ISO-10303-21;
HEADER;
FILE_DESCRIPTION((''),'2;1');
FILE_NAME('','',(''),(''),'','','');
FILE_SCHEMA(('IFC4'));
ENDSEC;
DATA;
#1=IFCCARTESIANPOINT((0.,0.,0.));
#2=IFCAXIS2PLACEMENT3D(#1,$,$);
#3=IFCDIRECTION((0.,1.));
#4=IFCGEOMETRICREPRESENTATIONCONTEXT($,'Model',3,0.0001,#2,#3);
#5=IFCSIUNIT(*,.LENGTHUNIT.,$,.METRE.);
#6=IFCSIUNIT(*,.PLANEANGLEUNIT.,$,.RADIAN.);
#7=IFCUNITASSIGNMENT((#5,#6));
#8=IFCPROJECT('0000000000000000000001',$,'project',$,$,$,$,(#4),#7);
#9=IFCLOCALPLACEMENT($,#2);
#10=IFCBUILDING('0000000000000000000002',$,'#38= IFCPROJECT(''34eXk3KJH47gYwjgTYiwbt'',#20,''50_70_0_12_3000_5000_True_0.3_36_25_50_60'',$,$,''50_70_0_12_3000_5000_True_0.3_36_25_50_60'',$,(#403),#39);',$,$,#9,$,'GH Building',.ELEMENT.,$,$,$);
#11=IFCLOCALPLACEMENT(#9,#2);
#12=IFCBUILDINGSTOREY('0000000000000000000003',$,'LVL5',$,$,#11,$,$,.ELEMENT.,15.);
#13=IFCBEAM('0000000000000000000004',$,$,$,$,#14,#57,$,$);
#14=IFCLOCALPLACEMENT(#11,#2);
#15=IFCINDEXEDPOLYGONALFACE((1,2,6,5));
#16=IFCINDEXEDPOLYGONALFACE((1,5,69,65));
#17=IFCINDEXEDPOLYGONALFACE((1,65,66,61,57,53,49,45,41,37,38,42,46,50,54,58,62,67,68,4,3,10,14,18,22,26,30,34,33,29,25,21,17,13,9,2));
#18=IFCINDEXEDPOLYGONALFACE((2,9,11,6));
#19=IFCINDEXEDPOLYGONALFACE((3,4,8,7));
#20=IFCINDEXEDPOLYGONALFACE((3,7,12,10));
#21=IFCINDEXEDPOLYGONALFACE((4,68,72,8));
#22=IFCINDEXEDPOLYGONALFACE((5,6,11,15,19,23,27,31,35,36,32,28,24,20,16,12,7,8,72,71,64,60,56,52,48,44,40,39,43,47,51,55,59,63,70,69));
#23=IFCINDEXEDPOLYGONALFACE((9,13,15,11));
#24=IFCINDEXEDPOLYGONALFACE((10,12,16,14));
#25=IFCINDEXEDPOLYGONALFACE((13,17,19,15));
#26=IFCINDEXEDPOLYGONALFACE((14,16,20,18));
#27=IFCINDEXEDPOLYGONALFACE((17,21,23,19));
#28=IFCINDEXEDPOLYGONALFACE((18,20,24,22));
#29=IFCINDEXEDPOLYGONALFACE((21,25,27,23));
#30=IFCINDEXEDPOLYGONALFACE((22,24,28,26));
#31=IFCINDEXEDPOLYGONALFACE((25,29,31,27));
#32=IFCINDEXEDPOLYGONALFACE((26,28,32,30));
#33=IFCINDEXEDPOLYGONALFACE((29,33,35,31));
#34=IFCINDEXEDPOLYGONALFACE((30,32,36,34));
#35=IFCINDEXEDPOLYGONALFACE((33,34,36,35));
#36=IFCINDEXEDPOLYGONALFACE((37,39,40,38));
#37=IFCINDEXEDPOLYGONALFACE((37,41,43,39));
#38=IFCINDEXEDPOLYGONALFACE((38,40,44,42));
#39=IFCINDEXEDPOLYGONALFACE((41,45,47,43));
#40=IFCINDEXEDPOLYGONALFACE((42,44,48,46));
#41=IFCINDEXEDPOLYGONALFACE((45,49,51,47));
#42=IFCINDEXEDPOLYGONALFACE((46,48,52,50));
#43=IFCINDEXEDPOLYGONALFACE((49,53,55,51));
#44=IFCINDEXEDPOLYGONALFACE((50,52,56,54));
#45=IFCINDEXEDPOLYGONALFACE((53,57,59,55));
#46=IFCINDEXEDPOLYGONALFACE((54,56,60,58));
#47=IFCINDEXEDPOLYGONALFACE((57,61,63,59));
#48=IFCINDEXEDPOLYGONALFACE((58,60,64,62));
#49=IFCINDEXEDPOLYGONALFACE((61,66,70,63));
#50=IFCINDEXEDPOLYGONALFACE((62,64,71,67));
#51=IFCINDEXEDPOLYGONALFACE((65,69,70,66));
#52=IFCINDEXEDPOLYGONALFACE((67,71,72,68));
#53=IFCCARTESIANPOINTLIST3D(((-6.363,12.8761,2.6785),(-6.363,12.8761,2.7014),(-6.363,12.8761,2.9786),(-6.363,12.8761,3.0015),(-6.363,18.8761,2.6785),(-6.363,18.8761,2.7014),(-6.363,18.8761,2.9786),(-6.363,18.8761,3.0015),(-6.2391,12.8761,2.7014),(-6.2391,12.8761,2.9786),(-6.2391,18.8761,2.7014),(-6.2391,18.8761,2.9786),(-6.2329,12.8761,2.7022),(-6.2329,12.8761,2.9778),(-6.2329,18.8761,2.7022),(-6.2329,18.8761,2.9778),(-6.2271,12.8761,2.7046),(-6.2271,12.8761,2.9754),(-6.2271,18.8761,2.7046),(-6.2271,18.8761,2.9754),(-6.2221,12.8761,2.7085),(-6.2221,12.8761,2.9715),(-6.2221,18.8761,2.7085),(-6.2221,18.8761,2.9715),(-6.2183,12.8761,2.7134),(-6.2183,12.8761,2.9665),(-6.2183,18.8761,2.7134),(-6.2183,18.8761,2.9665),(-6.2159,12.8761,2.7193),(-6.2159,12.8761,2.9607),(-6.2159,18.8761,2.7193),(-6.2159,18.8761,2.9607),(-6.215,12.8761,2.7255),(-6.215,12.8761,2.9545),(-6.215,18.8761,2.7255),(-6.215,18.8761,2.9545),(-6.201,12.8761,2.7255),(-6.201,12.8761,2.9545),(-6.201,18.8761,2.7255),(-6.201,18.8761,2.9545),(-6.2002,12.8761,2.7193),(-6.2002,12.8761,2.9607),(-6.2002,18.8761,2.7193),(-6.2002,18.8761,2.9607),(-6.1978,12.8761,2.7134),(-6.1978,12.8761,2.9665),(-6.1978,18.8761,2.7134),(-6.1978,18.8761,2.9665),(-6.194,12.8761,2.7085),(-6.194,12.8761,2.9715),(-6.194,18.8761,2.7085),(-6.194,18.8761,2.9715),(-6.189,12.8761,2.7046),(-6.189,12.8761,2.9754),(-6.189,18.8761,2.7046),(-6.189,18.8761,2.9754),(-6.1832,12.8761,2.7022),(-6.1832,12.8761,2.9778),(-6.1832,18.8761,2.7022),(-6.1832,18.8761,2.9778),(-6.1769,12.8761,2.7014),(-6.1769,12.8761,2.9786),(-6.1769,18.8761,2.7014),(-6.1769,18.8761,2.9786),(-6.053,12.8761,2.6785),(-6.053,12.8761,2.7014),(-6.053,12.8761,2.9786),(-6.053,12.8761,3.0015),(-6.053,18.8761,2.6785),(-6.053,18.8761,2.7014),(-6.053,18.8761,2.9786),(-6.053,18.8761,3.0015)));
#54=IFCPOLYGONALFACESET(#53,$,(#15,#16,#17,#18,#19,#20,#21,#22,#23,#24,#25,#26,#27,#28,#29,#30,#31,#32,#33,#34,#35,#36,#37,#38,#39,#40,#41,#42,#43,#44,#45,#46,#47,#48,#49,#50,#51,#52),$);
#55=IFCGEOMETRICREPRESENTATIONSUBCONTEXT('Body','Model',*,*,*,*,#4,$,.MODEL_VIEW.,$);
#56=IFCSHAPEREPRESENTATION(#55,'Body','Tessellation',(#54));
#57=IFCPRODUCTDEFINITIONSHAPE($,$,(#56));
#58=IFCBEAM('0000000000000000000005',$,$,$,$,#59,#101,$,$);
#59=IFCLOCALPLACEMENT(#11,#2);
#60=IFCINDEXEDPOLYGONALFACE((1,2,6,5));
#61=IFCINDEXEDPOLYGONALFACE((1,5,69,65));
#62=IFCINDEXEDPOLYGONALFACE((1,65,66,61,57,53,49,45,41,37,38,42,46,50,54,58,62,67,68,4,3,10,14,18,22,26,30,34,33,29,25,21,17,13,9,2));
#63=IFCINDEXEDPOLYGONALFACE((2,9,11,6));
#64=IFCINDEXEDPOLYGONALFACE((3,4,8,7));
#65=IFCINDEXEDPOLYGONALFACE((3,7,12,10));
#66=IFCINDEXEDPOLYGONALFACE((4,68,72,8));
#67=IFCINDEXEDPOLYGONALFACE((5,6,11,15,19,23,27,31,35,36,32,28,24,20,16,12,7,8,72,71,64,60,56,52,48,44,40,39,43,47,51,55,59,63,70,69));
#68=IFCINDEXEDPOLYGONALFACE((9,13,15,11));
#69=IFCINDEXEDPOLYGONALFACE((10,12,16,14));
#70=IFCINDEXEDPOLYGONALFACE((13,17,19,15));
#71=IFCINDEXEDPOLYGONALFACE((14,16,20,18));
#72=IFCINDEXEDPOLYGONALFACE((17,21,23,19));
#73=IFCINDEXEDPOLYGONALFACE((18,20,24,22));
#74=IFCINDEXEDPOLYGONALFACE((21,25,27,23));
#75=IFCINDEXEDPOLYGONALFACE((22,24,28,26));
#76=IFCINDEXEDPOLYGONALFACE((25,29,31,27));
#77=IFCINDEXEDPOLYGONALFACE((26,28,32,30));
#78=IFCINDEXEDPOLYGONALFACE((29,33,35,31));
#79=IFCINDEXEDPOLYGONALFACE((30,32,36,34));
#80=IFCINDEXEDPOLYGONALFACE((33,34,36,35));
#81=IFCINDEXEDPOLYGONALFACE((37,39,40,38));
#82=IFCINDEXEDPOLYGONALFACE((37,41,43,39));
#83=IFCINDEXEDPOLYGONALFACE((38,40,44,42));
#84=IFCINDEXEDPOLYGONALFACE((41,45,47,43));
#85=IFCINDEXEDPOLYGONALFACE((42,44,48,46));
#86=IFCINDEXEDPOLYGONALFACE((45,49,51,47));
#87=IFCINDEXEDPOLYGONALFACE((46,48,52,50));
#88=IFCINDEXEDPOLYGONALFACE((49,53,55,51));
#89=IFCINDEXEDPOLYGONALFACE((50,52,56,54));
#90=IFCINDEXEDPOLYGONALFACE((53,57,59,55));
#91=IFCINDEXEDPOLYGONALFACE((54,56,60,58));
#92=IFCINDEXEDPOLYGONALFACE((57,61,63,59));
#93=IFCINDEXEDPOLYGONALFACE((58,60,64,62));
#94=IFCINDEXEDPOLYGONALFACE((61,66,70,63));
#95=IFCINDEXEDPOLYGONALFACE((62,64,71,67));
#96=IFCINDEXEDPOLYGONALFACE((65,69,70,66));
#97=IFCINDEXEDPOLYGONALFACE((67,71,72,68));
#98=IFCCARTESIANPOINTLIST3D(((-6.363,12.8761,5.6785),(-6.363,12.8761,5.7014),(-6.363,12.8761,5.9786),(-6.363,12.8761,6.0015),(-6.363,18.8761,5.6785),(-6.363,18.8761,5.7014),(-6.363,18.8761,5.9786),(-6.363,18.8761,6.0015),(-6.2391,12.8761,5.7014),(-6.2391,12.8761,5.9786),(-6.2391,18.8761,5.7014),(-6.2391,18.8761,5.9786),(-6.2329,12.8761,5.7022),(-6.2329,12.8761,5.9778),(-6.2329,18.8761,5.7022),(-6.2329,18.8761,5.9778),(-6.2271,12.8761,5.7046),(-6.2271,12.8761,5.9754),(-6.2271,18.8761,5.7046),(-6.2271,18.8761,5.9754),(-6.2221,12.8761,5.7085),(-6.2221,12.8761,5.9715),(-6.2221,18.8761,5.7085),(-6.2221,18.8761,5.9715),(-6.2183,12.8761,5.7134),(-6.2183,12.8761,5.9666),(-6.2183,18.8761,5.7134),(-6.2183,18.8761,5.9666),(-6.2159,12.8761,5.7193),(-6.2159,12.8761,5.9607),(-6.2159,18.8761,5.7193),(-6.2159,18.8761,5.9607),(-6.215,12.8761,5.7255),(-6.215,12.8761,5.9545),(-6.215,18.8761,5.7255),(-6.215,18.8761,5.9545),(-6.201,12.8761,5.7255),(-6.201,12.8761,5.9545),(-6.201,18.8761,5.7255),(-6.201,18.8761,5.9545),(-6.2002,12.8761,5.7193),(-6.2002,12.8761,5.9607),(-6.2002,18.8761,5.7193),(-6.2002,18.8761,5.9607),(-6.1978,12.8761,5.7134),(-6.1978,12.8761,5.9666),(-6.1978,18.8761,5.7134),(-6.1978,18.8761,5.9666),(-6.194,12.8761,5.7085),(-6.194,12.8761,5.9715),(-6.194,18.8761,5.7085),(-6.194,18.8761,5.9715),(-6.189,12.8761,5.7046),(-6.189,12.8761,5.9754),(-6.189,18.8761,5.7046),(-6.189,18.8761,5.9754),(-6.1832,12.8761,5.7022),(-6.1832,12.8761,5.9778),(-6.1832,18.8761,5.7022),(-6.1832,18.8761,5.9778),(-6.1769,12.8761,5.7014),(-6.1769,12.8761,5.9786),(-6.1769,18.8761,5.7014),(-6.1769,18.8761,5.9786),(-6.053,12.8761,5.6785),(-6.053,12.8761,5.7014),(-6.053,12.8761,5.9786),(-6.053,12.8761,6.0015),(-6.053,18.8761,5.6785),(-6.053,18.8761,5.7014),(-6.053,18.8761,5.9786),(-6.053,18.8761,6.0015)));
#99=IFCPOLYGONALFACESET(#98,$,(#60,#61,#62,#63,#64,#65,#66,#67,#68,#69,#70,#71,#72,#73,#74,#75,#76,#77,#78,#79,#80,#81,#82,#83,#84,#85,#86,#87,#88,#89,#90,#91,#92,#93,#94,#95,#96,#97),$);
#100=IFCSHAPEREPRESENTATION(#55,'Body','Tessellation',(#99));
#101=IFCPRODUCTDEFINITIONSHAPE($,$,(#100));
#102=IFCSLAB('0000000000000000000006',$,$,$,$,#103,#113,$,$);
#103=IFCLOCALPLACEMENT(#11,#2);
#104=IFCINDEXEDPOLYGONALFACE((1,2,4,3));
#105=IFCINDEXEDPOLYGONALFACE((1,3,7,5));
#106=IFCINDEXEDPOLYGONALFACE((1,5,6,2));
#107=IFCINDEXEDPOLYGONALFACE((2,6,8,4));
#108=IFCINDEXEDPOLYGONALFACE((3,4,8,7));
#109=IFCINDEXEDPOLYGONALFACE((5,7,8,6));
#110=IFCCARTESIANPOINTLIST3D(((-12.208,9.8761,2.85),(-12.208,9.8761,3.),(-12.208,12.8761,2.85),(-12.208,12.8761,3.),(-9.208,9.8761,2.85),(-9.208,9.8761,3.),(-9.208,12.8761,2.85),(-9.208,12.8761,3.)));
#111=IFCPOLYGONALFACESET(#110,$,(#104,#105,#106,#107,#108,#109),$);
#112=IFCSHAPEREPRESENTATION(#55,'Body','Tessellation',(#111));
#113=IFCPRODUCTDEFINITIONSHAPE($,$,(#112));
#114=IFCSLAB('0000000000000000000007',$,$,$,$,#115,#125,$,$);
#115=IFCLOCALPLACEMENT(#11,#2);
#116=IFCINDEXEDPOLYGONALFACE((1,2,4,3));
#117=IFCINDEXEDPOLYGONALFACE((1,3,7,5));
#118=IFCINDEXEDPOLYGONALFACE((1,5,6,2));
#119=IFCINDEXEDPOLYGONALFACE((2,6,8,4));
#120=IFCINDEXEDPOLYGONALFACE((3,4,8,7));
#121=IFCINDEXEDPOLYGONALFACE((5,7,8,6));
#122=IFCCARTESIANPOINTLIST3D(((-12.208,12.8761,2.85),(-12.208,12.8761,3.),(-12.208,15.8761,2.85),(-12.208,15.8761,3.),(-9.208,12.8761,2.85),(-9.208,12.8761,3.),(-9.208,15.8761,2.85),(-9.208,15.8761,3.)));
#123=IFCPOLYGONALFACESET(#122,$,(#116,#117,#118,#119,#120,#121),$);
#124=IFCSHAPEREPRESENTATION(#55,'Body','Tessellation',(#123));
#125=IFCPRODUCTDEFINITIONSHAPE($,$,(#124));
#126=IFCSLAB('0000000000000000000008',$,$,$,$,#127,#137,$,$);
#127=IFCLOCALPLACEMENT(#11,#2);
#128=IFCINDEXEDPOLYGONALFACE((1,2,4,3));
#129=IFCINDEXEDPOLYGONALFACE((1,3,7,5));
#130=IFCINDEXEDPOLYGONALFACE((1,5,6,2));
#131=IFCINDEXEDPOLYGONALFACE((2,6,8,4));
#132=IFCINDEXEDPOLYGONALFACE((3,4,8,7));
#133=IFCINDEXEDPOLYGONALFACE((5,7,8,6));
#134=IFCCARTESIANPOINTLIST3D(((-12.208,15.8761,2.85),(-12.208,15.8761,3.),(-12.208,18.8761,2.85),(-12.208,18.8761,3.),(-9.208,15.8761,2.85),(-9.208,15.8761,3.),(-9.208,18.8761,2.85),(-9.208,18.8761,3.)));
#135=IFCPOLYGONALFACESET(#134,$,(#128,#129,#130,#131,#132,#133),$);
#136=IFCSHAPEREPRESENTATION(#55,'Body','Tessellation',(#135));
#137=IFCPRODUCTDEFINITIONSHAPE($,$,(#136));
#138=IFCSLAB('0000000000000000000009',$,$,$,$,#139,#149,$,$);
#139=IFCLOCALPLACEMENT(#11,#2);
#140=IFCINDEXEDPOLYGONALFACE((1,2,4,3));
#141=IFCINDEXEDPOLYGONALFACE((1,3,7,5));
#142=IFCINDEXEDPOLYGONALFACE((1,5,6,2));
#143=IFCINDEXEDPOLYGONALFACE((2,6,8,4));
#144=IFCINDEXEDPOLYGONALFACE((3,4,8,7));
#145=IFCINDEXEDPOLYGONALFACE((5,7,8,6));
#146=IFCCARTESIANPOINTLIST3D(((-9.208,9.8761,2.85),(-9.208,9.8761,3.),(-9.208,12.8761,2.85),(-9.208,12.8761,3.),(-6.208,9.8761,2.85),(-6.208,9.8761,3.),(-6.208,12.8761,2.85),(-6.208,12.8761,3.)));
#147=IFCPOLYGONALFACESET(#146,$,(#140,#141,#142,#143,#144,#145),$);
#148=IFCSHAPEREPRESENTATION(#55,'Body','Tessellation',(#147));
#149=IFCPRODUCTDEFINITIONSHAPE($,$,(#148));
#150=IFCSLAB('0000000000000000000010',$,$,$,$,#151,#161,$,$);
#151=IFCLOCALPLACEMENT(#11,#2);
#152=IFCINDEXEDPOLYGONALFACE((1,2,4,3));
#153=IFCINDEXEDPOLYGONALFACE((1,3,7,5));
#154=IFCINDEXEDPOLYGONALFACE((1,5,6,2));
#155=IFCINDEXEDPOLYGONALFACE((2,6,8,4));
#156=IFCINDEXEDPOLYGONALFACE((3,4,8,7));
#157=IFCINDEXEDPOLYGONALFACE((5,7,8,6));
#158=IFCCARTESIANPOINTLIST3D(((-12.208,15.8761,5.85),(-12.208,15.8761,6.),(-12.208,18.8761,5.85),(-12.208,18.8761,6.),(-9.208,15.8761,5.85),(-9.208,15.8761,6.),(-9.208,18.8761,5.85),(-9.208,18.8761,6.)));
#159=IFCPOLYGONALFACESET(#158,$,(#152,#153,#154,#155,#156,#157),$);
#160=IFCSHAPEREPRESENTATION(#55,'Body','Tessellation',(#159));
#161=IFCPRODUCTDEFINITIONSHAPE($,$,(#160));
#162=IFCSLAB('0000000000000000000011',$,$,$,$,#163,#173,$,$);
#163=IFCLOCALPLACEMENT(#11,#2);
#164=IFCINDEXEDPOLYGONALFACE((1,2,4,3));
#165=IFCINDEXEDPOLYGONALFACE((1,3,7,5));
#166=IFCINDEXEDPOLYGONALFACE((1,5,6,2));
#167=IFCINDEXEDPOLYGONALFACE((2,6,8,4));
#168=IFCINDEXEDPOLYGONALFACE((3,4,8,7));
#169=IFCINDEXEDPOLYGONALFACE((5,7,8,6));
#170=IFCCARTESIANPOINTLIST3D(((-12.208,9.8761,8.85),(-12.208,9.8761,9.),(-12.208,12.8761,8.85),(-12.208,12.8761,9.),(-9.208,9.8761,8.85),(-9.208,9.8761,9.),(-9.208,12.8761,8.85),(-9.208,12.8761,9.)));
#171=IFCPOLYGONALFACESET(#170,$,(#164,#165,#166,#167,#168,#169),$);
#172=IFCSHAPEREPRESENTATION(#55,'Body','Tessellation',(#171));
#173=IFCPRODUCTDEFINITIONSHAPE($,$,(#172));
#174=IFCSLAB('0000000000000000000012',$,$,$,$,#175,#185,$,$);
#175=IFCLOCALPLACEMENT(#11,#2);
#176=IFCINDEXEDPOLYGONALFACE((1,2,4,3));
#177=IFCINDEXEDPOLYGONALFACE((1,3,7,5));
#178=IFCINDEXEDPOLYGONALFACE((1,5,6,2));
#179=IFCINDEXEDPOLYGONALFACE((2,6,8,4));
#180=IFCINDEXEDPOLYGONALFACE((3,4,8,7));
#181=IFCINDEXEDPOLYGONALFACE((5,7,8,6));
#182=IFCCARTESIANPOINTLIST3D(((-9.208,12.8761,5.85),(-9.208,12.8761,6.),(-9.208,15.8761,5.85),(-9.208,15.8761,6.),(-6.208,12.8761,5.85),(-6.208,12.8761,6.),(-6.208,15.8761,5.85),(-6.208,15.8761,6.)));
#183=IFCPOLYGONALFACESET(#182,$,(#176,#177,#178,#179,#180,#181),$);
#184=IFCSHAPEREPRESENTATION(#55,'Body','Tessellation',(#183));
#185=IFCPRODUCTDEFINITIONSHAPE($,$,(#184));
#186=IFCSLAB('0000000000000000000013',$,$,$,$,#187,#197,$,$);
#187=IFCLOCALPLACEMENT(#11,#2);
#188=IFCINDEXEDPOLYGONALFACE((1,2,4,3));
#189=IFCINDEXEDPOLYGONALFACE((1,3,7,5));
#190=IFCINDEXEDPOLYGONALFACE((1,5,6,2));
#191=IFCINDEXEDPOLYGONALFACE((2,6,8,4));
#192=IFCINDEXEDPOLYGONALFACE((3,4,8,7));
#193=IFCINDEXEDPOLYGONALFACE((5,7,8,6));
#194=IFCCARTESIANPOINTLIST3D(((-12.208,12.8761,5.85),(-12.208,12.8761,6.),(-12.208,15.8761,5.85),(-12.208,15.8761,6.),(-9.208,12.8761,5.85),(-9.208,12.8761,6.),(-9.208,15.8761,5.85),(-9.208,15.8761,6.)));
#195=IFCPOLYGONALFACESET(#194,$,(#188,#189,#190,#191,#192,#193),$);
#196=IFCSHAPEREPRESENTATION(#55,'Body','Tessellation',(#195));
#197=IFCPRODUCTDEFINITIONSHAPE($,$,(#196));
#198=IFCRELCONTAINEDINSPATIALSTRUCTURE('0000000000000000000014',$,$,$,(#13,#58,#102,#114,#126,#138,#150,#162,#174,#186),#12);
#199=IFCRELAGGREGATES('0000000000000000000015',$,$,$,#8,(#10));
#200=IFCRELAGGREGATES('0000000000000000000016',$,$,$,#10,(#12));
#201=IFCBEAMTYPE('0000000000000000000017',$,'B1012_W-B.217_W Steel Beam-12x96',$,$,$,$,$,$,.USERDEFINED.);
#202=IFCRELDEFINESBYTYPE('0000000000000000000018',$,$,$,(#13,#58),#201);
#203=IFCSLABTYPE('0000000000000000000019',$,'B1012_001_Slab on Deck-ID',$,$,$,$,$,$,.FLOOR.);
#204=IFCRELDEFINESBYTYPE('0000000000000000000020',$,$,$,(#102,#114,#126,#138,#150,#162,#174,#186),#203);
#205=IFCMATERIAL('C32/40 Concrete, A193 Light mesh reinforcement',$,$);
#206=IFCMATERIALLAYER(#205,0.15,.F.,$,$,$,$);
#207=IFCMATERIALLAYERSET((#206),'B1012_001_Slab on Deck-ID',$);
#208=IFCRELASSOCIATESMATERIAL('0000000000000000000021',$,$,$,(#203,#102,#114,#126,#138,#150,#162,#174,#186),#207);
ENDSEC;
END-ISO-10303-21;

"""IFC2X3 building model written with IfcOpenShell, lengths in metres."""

from ifc_helpers import new_model, si_unit, direction, frame, origin, origin_2d, place, context, subcontext, project, spatial, polyline, i_section, outline, extrude, material, layer, layer_set, layer_usage, type_object, element, save


model = new_model("IFC2X3")

# Units and contexts
model_context = context("Model", 3, precision=0.0001, world=origin(), true_north=direction((0.0, 1.0)))
body_context = subcontext(model_context, "Body", "Model", "MODEL_VIEW")
ifc_project = project(units=[si_unit("LENGTHUNIT", "METRE"), si_unit("PLANEANGLEUNIT", "RADIAN")], contexts=[model_context])

# Building, storey
building_placement = place(None, origin())
building = spatial("IfcBuilding", under=ifc_project, at=building_placement, Name="#38= IFCPROJECT('34eXk3KJH47gYwjgTYiwbt',#20,'50_70_0_12_3000_5000_True_0.3_36_25_50_60',$,$,'50_70_0_12_3000_5000_True_0.3_36_25_50_60',$,(#403),#39);", LongName="GH Building", CompositionType="ELEMENT")
storey_placement = place(building_placement, origin())
storey = spatial("IfcBuildingStorey", under=building, at=storey_placement, Name="LVL5", CompositionType="ELEMENT", Elevation=15.0)

# Beams
beam_type = type_object("IfcBeamType", Name="B1012_W-B.217_W Steel Beam-12x96", PredefinedType="USERDEFINED")
for number, where, z_axis, x_axis in (
    (1, (-6.208, 12.8761, 2.84), (0.0, 1.0, 0.0), (-1.0, 0.0, 0.0)),
    (2, (-6.208, 12.8761, 5.84), (0.0, 1.0, 0.0), (-1.0, 0.0, 0.0)),
):
    element("IfcBeam", number, at=place(storey_placement, frame(where, z_axis=z_axis, x_axis=x_axis)), inside=storey, type_object=beam_type, context=body_context, shape_type="SweptSolid", body=[
        extrude(i_section(OverallWidth=0.31, OverallDepth=0.323, WebThickness=0.014, FlangeThickness=0.0229, FilletRadius=0.0241, at=origin_2d()), origin(), (0.0, 0.0, 1.0), 6.0),
    ])

# Slabs
ifc_material_1 = material(Name="C32/40 Concrete, A193 Light mesh reinforcement")
ifc_layer_1 = layer(ifc_material_1, 0.15, ventilated=False)
ifc_layer_set_1 = layer_set([ifc_layer_1], Name="B1012_001_Slab on Deck-ID")
ifc_layer_usage_1 = layer_usage(ifc_layer_set_1, "AXIS3", "NEGATIVE", -0.15)
slab_type_1 = type_object("IfcSlabType", Name="B1012_001_Slab on Deck-ID", PredefinedType="FLOOR", material=ifc_layer_set_1)
slab_1_placement = place(storey_placement, frame((-10.708, 11.3761, 2.85), z_axis=(0.0, 0.0, 1.0), x_axis=(0.0, 1.0, 0.0)))
element("IfcSlab", 3, at=slab_1_placement, inside=storey, type_object=slab_type_1, material=ifc_layer_usage_1, context=body_context, shape_type="SweptSolid", body=[
    extrude(outline(polyline([(-1.5, -1.5), (1.5, -1.5), (1.5, 1.5), (-1.5, 1.5), (-1.5, -1.5)])), origin(), (0.0, 0.0, 1.0), 0.15),
])
ifc_layer_usage_2 = layer_usage(ifc_layer_set_1, "AXIS3", "NEGATIVE", -0.15)
slab_2_placement = place(storey_placement, frame((-10.708, 14.3761, 2.85), z_axis=(0.0, 0.0, 1.0), x_axis=(0.0, 1.0, 0.0)))
element("IfcSlab", 4, at=slab_2_placement, inside=storey, type_object=slab_type_1, material=ifc_layer_usage_2, context=body_context, shape_type="SweptSolid", body=[
    extrude(outline(polyline([(-1.5, -1.5), (1.5, -1.5), (1.5, 1.5), (-1.5, 1.5), (-1.5, -1.5)])), origin(), (0.0, 0.0, 1.0), 0.15),
])
ifc_layer_usage_3 = layer_usage(ifc_layer_set_1, "AXIS3", "NEGATIVE", -0.15)
slab_3_placement = place(storey_placement, frame((-10.708, 17.3761, 2.85), z_axis=(0.0, 0.0, 1.0), x_axis=(0.0, 1.0, 0.0)))
element("IfcSlab", 5, at=slab_3_placement, inside=storey, type_object=slab_type_1, material=ifc_layer_usage_3, context=body_context, shape_type="SweptSolid", body=[
    extrude(outline(polyline([(-1.5, -1.5), (1.5, -1.5), (1.5, 1.5), (-1.5, 1.5), (-1.5, -1.5)])), origin(), (0.0, 0.0, 1.0), 0.15),
])
ifc_layer_usage_4 = layer_usage(ifc_layer_set_1, "AXIS3", "NEGATIVE", -0.15)
slab_4_placement = place(storey_placement, frame((-7.708, 11.3761, 2.85), z_axis=(0.0, 0.0, 1.0), x_axis=(0.0, 1.0, 0.0)))
element("IfcSlab", 6, at=slab_4_placement, inside=storey, type_object=slab_type_1, material=ifc_layer_usage_4, context=body_context, shape_type="SweptSolid", body=[
    extrude(outline(polyline([(-1.5, -1.5), (1.5, -1.5), (1.5, 1.5), (-1.5, 1.5), (-1.5, -1.5)])), origin(), (0.0, 0.0, 1.0), 0.15),
])
ifc_layer_usage_5 = layer_usage(ifc_layer_set_1, "AXIS3", "NEGATIVE", -0.15)
slab_5_placement = place(storey_placement, frame((-10.708, 17.3761, 5.85)))
element("IfcSlab", 7, at=slab_5_placement, inside=storey, type_object=slab_type_1, material=ifc_layer_usage_5, context=body_context, shape_type="SweptSolid", body=[
    extrude(outline(polyline([(1.5, -1.5), (-1.5, -1.5), (-1.5, 1.5), (1.5, 1.5), (1.5, -1.5)])), origin(), (0.0, 0.0, 1.0), 0.15),
])
ifc_layer_usage_6 = layer_usage(ifc_layer_set_1, "AXIS3", "NEGATIVE", -0.15)
slab_6_placement = place(storey_placement, frame((-10.708, 11.3761, 8.85)))
element("IfcSlab", 8, at=slab_6_placement, inside=storey, type_object=slab_type_1, material=ifc_layer_usage_6, context=body_context, shape_type="SweptSolid", body=[
    extrude(outline(polyline([(1.5, -1.5), (-1.5, -1.5), (-1.5, 1.5), (1.5, 1.5), (1.5, -1.5)])), origin(), (0.0, 0.0, 1.0), 0.15),
])
ifc_layer_usage_7 = layer_usage(ifc_layer_set_1, "AXIS3", "NEGATIVE", -0.15)
slab_7_placement = place(storey_placement, frame((-7.708, 14.3761, 5.85)))
element("IfcSlab", 9, at=slab_7_placement, inside=storey, type_object=slab_type_1, material=ifc_layer_usage_7, context=body_context, shape_type="SweptSolid", body=[
    extrude(outline(polyline([(-1.5, 1.5), (1.5, 1.5), (1.5, -1.5), (-1.5, -1.5), (-1.5, 1.5)])), origin(), (0.0, 0.0, 1.0), 0.15),
])
ifc_layer_usage_8 = layer_usage(ifc_layer_set_1, "AXIS3", "NEGATIVE", -0.15)
slab_8_placement = place(storey_placement, frame((-10.708, 14.3761, 5.85)))
element("IfcSlab", 10, at=slab_8_placement, inside=storey, type_object=slab_type_1, material=ifc_layer_usage_8, context=body_context, shape_type="SweptSolid", body=[
    extrude(outline(polyline([(1.5, -1.5), (-1.5, -1.5), (-1.5, 1.5), (1.5, 1.5), (1.5, -1.5)])), origin(), (0.0, 0.0, 1.0), 0.15),
])

save(model, "model.ifc")
